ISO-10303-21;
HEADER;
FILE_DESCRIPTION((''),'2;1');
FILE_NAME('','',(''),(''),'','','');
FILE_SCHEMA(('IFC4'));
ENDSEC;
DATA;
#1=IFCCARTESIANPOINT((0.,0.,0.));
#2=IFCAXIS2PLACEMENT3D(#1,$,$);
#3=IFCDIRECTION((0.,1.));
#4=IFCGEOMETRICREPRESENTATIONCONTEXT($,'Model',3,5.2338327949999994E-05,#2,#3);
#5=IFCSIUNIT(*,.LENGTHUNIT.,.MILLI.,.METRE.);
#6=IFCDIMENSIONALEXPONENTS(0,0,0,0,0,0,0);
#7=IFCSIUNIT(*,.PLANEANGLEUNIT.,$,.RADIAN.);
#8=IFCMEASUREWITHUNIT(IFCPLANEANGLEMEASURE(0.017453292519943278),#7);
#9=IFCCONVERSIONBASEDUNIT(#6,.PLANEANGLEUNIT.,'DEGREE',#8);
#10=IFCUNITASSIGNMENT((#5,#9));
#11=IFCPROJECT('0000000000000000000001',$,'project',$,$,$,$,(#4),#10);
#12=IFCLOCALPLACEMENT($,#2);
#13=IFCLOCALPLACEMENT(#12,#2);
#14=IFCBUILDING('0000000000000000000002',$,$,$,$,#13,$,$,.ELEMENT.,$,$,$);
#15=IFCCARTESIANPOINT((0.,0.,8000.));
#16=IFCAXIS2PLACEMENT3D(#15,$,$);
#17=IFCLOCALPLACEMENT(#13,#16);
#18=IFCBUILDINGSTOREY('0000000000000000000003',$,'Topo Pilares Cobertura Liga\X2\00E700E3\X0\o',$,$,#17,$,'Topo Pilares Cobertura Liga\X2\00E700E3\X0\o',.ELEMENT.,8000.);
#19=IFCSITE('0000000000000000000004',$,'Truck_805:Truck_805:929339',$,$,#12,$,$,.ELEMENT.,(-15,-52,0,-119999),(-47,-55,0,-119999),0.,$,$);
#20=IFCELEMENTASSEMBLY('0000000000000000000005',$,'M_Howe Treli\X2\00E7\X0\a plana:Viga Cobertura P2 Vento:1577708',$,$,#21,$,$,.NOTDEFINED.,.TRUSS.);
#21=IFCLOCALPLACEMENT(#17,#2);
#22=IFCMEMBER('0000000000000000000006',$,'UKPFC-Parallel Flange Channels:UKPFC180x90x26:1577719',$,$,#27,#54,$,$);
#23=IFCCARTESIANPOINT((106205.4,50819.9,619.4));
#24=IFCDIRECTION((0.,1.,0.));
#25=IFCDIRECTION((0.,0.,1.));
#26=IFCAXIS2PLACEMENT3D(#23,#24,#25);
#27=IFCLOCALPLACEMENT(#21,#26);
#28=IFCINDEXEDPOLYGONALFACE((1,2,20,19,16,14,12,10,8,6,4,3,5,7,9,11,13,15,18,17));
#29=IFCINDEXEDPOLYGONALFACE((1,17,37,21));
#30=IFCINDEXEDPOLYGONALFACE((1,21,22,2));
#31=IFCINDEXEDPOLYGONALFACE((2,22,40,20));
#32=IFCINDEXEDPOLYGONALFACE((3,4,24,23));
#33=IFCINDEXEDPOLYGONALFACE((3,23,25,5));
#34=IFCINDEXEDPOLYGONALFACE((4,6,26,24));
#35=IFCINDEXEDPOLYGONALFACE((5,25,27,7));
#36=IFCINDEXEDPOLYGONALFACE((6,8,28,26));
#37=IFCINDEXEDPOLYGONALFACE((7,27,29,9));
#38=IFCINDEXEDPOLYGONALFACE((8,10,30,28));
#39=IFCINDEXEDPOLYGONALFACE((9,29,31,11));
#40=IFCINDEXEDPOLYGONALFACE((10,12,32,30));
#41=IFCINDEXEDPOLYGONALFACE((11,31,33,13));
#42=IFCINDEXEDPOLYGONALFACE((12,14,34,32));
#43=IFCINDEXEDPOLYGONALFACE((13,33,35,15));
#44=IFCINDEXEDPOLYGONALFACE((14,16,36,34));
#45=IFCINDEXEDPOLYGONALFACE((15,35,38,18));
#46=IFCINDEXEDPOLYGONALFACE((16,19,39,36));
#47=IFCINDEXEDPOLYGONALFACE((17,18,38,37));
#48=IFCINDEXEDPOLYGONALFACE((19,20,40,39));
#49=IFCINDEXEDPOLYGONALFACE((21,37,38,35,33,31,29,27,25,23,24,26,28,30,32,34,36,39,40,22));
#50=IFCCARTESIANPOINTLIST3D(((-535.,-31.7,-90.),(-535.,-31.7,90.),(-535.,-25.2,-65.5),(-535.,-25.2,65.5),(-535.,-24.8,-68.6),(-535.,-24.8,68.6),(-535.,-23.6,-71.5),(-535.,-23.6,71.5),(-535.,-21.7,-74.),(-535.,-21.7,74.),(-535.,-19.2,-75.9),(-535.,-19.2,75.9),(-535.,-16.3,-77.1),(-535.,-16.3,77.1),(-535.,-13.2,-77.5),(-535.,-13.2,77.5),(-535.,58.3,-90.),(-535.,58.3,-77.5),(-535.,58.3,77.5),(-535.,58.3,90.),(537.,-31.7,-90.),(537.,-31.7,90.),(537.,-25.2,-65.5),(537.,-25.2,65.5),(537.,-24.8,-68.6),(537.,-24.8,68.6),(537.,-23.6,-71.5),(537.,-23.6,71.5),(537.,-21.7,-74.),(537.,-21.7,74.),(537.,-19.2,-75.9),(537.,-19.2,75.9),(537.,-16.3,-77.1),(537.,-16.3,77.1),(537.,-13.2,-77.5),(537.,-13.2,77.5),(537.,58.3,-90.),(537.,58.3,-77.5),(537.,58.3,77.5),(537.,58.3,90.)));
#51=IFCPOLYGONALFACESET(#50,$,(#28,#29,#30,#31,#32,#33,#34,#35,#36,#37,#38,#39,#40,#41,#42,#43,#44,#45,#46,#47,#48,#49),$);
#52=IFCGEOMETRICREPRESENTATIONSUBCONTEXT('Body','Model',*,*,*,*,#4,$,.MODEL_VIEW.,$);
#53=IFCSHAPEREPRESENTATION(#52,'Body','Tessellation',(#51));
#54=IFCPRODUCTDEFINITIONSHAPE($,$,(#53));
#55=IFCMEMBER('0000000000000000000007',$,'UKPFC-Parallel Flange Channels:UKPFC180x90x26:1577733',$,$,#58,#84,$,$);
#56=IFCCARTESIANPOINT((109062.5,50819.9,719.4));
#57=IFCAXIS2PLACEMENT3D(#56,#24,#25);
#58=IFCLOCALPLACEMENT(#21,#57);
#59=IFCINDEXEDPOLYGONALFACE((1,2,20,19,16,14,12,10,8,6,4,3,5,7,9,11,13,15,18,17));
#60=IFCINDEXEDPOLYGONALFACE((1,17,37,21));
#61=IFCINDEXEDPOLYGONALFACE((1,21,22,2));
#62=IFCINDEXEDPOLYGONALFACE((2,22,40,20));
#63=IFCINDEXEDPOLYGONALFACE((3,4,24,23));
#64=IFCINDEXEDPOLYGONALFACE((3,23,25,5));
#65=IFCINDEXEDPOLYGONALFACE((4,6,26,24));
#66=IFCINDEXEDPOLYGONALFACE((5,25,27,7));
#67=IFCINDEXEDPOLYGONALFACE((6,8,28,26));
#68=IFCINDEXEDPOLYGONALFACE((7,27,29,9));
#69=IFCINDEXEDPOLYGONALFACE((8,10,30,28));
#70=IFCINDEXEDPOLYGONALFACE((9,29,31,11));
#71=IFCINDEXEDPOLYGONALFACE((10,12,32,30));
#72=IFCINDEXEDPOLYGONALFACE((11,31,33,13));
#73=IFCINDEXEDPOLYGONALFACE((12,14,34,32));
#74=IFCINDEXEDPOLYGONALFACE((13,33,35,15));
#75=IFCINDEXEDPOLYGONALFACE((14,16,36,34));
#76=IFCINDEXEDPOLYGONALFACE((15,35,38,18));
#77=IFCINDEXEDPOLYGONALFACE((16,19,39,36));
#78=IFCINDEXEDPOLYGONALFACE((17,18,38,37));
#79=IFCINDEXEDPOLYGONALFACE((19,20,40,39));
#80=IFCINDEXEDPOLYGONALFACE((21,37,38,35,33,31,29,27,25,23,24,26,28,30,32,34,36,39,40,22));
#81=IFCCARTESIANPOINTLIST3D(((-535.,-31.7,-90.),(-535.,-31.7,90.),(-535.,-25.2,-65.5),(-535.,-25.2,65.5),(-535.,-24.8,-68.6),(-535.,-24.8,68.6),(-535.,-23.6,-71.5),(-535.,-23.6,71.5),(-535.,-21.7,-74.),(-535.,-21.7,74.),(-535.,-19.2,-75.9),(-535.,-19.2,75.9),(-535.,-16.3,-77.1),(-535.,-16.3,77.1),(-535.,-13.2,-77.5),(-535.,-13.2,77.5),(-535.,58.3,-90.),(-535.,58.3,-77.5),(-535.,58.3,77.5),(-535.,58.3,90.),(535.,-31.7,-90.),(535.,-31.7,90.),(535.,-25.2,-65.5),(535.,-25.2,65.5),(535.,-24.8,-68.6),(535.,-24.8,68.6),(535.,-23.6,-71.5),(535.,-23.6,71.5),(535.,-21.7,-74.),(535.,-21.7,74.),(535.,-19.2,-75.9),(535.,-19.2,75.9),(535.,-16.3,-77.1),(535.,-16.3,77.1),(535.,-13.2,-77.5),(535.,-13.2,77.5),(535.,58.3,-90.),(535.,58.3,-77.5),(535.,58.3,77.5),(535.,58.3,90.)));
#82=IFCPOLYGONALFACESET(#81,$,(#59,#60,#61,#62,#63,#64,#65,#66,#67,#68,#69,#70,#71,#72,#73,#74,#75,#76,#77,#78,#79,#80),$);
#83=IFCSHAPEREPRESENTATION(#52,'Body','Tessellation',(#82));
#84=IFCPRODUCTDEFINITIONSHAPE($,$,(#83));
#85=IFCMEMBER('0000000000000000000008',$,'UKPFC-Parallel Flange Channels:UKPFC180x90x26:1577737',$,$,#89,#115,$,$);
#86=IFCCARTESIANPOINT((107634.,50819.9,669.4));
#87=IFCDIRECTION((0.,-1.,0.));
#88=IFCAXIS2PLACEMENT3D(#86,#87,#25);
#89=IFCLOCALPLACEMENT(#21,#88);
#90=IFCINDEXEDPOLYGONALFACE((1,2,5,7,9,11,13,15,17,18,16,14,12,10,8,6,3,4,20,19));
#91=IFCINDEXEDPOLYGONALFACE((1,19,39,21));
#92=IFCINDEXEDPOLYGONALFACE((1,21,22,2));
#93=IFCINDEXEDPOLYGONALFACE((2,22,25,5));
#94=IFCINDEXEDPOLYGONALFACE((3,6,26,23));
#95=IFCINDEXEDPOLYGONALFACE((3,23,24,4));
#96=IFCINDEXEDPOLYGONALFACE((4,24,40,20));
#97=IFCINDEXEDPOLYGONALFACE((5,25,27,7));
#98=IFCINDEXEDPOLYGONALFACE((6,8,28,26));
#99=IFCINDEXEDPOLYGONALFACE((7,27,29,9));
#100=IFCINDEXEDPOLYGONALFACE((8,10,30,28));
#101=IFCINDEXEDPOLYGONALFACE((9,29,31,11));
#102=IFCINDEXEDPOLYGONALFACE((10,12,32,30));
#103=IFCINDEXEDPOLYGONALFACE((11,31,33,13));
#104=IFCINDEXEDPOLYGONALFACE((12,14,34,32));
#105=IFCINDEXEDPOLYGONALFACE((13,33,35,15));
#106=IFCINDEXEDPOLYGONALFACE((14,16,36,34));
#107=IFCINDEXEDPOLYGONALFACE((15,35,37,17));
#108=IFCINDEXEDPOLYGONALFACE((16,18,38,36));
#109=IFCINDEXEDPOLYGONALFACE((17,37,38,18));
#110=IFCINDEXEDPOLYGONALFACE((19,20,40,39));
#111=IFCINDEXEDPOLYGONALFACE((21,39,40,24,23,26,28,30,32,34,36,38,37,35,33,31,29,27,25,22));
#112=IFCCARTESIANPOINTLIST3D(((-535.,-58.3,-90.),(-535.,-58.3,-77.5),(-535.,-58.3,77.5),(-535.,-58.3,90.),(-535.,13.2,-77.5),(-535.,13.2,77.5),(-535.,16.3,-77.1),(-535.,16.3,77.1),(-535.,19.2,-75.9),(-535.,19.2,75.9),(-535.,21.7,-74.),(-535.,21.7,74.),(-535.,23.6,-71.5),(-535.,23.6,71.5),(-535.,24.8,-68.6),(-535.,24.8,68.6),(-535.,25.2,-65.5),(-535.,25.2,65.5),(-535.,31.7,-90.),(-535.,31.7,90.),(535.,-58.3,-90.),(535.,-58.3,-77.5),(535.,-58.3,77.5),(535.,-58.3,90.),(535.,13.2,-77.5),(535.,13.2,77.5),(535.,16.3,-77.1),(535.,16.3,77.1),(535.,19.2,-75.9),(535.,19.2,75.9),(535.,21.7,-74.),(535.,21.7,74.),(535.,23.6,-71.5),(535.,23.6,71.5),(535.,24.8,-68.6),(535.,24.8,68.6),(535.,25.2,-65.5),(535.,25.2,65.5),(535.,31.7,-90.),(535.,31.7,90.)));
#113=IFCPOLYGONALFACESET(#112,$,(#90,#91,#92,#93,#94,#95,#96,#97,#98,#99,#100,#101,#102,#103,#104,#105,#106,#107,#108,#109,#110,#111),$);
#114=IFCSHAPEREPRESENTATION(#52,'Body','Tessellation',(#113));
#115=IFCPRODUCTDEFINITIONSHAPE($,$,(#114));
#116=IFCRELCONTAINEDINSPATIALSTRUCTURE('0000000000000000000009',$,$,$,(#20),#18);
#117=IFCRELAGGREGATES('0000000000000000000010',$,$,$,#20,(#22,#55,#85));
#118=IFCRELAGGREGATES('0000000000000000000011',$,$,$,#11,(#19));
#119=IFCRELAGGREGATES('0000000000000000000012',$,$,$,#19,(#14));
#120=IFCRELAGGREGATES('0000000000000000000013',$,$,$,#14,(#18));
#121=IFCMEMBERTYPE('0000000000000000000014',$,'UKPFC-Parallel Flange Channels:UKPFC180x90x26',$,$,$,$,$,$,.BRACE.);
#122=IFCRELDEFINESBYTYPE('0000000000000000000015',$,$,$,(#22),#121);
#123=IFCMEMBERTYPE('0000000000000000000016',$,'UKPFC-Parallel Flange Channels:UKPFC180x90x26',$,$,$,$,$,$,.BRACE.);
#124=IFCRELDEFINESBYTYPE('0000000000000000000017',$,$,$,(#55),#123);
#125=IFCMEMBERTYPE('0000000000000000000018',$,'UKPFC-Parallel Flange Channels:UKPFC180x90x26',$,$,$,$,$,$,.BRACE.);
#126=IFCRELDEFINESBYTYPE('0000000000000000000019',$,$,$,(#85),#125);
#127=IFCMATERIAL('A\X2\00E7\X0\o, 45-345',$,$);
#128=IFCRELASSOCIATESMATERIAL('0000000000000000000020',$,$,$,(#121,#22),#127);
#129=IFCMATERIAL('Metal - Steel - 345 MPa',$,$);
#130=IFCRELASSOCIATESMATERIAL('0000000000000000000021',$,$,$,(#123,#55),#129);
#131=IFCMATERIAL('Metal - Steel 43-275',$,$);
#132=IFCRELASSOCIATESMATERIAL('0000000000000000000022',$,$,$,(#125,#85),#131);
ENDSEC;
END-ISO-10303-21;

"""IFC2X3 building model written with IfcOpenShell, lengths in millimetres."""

from ifc_helpers import new_model, entity, si_unit, converted_unit, direction, frame, frame_2d, origin, place, context, subcontext, project, spatial, polyline, circle_curve, parameter, trimmed, segment, composite_curve, outline, extrude, source, transform, mapped, material, type_object, type_shapes, element, aggregate, save


model = new_model("IFC2X3")

# Units and contexts
model_context = context("Model", 3, precision=5.2338327949999994e-05, world=origin(), true_north=direction((0.0, 1.0)))
body_context = subcontext(model_context, "Body", "Model", "MODEL_VIEW")
ifc_project = project(units=[si_unit("LENGTHUNIT", "METRE", prefix="MILLI"), converted_unit("PLANEANGLEUNIT", "DEGREE", entity("IfcPlaneAngleMeasure", 0.017453292519943278), si_unit("PLANEANGLEUNIT", "RADIAN"), dimensions=[0, 0, 0, 0, 0, 0, 0])], contexts=[model_context])

# Site, building, storey
site_placement = place(None, origin())
site = spatial("IfcSite", under=ifc_project, at=site_placement, Name="Truck_805:Truck_805:929339", CompositionType="ELEMENT", RefLatitude=(-15, -52, 0, -119999), RefLongitude=(-47, -55, 0, -119999), RefElevation=0.0)
building_placement = place(site_placement, origin())
building = spatial("IfcBuilding", under=site, at=building_placement, CompositionType="ELEMENT")
storey_placement = place(building_placement, frame((0.0, 0.0, 8000.0)))
storey = spatial("IfcBuildingStorey", under=building, at=storey_placement, Name="Topo Pilares Cobertura Ligação", LongName="Topo Pilares Cobertura Ligação", CompositionType="ELEMENT", Elevation=8000.0)

# Element assembly, member
ifc_material_1 = material(Name="Aço, 45-345")
member_type_1 = type_object("IfcMemberType", Name="UKPFC-Parallel Flange Channels:UKPFC180x90x26", PredefinedType="BRACE", material=ifc_material_1)
shared_shape_1 = source(origin(), body_context, "Body", "SweptSolid", [
    extrude(outline(composite_curve([segment(polyline([(-90.0, -41.0), (90.0, -41.0)]), True, "CONTINUOUS"), segment(polyline([(90.0, -41.0), (90.0, 49.0)]), True, "CONTINUOUS"), segment(polyline([(90.0, 49.0), (77.5, 49.0)]), True, "CONTINUOUS"), segment(polyline([(77.5, 49.0), (77.5, -22.5)]), True, "CONTINUOUS"), segment(trimmed(circle_curve(frame_2d((65.5, -22.5), x_axis=(1.0, 0.0)), 12.0), [parameter(270.0)], [parameter(0.0)], True, "PARAMETER"), False, "CONTINUOUS"), segment(polyline([(65.5, -34.5), (-65.5, -34.5)]), True, "CONTINUOUS"), segment(trimmed(circle_curve(frame_2d((-65.5, -22.5), x_axis=(0.0, -1.0)), 12.0), [parameter(270.0)], [parameter(0.0)], True, "PARAMETER"), False, "CONTINUOUS"), segment(polyline([(-77.5, -22.5), (-77.5, 49.0)]), True, "CONTINUOUS"), segment(polyline([(-77.5, 49.0), (-90.0, 49.0)]), True, "CONTINUOUS"), segment(polyline([(-90.0, 49.0), (-90.0, -41.0)]), True, "CONTINUOUS")], self_intersect=False)), frame((-535.0, 9.3, 0.0), z_axis=(1.0, 0.0, 0.0), x_axis=(0.0, 0.0, -1.0)), (0.0, 0.0, 1.0), 1072.0),
])
type_shapes(member_type_1, [shared_shape_1])
assembly_1_placement = place(storey_placement, origin())
assembly_1 = element("IfcElementAssembly", 1, at=assembly_1_placement, inside=storey, Name="M_Howe Treliça plana:Viga Cobertura P2 Vento:1577708", AssemblyPlace="NOTDEFINED", PredefinedType="TRUSS")
member_1_placement = place(assembly_1_placement, frame((106205.4, 50819.9, 619.4), z_axis=(0.0, 1.0, 0.0), x_axis=(0.0, 0.0, 1.0)))
member_1 = element("IfcMember", 2, at=member_1_placement, type_object=member_type_1, material=ifc_material_1, Name="UKPFC-Parallel Flange Channels:UKPFC180x90x26:1577719", context=body_context, shape_type="MappedRepresentation", body=[
    mapped(shared_shape_1, transform((0.0, 0.0, 0.0), scale=1.0)),
])

# Members
ifc_material_2 = material(Name="Metal - Steel - 345 MPa")
member_type_2 = type_object("IfcMemberType", Name="UKPFC-Parallel Flange Channels:UKPFC180x90x26", PredefinedType="BRACE", material=ifc_material_2)
shared_shape_2 = source(origin(), body_context, "Body", "SweptSolid", [
    extrude(outline(composite_curve([segment(polyline([(-90.0, -41.0), (90.0, -41.0)]), True, "CONTINUOUS"), segment(polyline([(90.0, -41.0), (90.0, 49.0)]), True, "CONTINUOUS"), segment(polyline([(90.0, 49.0), (77.5, 49.0)]), True, "CONTINUOUS"), segment(polyline([(77.5, 49.0), (77.5, -22.5)]), True, "CONTINUOUS"), segment(trimmed(circle_curve(frame_2d((65.5, -22.5), x_axis=(1.0, 0.0)), 12.0), [parameter(270.0)], [parameter(0.0)], True, "PARAMETER"), False, "CONTINUOUS"), segment(polyline([(65.5, -34.5), (-65.5, -34.5)]), True, "CONTINUOUS"), segment(trimmed(circle_curve(frame_2d((-65.5, -22.5), x_axis=(0.0, -1.0)), 12.0), [parameter(270.0)], [parameter(0.0)], True, "PARAMETER"), False, "CONTINUOUS"), segment(polyline([(-77.5, -22.5), (-77.5, 49.0)]), True, "CONTINUOUS"), segment(polyline([(-77.5, 49.0), (-90.0, 49.0)]), True, "CONTINUOUS"), segment(polyline([(-90.0, 49.0), (-90.0, -41.0)]), True, "CONTINUOUS")], self_intersect=False)), frame((-535.0, 9.3, 0.0), z_axis=(1.0, 0.0, 0.0), x_axis=(0.0, 0.0, -1.0)), (0.0, 0.0, 1.0), 1070.0),
])
type_shapes(member_type_2, [shared_shape_2])
member_2_placement = place(assembly_1_placement, frame((109062.5, 50819.9, 719.4), z_axis=(0.0, 1.0, 0.0), x_axis=(0.0, 0.0, 1.0)))
member_2 = element("IfcMember", 3, at=member_2_placement, type_object=member_type_2, material=ifc_material_2, Name="UKPFC-Parallel Flange Channels:UKPFC180x90x26:1577733", context=body_context, shape_type="MappedRepresentation", body=[
    mapped(shared_shape_2, transform((0.0, 0.0, 0.0), scale=1.0)),
])
ifc_material_3 = material(Name="Metal - Steel 43-275")
member_type_3 = type_object("IfcMemberType", Name="UKPFC-Parallel Flange Channels:UKPFC180x90x26", PredefinedType="BRACE", material=ifc_material_3)
shared_shape_3 = source(origin(), body_context, "Body", "SweptSolid", [
    extrude(outline(composite_curve([segment(polyline([(-90.0, -49.0), (-77.5, -49.0)]), True, "CONTINUOUS"), segment(polyline([(-77.5, -49.0), (-77.5, 22.5)]), True, "CONTINUOUS"), segment(trimmed(circle_curve(frame_2d((-65.5, 22.5), x_axis=(-1.0, 0.0)), 12.0), [parameter(270.0)], [parameter(0.0)], True, "PARAMETER"), False, "CONTINUOUS"), segment(polyline([(-65.5, 34.5), (65.5, 34.5)]), True, "CONTINUOUS"), segment(trimmed(circle_curve(frame_2d((65.5, 22.5), x_axis=(0.0, 1.0)), 12.0), [parameter(270.0)], [parameter(0.0)], True, "PARAMETER"), False, "CONTINUOUS"), segment(polyline([(77.5, 22.5), (77.5, -49.0)]), True, "CONTINUOUS"), segment(polyline([(77.5, -49.0), (90.0, -49.0)]), True, "CONTINUOUS"), segment(polyline([(90.0, -49.0), (90.0, 41.0)]), True, "CONTINUOUS"), segment(polyline([(90.0, 41.0), (-90.0, 41.0)]), True, "CONTINUOUS"), segment(polyline([(-90.0, 41.0), (-90.0, -49.0)]), True, "CONTINUOUS")], self_intersect=False)), frame((-535.0, -9.3, 0.0), z_axis=(1.0, 0.0, 0.0), x_axis=(0.0, 0.0, -1.0)), (0.0, 0.0, 1.0), 1070.0),
])
type_shapes(member_type_3, [shared_shape_3])
member_3_placement = place(assembly_1_placement, frame((107634.0, 50819.9, 669.4), z_axis=(0.0, -1.0, 0.0), x_axis=(0.0, 0.0, 1.0)))
member_3 = element("IfcMember", 4, at=member_3_placement, type_object=member_type_3, material=ifc_material_3, Name="UKPFC-Parallel Flange Channels:UKPFC180x90x26:1577737", context=body_context, shape_type="MappedRepresentation", body=[
    mapped(shared_shape_3, transform((0.0, 0.0, 0.0), scale=1.0)),
])
aggregate(assembly_1, [member_1, member_2, member_3])

save(model, "model.ifc")
